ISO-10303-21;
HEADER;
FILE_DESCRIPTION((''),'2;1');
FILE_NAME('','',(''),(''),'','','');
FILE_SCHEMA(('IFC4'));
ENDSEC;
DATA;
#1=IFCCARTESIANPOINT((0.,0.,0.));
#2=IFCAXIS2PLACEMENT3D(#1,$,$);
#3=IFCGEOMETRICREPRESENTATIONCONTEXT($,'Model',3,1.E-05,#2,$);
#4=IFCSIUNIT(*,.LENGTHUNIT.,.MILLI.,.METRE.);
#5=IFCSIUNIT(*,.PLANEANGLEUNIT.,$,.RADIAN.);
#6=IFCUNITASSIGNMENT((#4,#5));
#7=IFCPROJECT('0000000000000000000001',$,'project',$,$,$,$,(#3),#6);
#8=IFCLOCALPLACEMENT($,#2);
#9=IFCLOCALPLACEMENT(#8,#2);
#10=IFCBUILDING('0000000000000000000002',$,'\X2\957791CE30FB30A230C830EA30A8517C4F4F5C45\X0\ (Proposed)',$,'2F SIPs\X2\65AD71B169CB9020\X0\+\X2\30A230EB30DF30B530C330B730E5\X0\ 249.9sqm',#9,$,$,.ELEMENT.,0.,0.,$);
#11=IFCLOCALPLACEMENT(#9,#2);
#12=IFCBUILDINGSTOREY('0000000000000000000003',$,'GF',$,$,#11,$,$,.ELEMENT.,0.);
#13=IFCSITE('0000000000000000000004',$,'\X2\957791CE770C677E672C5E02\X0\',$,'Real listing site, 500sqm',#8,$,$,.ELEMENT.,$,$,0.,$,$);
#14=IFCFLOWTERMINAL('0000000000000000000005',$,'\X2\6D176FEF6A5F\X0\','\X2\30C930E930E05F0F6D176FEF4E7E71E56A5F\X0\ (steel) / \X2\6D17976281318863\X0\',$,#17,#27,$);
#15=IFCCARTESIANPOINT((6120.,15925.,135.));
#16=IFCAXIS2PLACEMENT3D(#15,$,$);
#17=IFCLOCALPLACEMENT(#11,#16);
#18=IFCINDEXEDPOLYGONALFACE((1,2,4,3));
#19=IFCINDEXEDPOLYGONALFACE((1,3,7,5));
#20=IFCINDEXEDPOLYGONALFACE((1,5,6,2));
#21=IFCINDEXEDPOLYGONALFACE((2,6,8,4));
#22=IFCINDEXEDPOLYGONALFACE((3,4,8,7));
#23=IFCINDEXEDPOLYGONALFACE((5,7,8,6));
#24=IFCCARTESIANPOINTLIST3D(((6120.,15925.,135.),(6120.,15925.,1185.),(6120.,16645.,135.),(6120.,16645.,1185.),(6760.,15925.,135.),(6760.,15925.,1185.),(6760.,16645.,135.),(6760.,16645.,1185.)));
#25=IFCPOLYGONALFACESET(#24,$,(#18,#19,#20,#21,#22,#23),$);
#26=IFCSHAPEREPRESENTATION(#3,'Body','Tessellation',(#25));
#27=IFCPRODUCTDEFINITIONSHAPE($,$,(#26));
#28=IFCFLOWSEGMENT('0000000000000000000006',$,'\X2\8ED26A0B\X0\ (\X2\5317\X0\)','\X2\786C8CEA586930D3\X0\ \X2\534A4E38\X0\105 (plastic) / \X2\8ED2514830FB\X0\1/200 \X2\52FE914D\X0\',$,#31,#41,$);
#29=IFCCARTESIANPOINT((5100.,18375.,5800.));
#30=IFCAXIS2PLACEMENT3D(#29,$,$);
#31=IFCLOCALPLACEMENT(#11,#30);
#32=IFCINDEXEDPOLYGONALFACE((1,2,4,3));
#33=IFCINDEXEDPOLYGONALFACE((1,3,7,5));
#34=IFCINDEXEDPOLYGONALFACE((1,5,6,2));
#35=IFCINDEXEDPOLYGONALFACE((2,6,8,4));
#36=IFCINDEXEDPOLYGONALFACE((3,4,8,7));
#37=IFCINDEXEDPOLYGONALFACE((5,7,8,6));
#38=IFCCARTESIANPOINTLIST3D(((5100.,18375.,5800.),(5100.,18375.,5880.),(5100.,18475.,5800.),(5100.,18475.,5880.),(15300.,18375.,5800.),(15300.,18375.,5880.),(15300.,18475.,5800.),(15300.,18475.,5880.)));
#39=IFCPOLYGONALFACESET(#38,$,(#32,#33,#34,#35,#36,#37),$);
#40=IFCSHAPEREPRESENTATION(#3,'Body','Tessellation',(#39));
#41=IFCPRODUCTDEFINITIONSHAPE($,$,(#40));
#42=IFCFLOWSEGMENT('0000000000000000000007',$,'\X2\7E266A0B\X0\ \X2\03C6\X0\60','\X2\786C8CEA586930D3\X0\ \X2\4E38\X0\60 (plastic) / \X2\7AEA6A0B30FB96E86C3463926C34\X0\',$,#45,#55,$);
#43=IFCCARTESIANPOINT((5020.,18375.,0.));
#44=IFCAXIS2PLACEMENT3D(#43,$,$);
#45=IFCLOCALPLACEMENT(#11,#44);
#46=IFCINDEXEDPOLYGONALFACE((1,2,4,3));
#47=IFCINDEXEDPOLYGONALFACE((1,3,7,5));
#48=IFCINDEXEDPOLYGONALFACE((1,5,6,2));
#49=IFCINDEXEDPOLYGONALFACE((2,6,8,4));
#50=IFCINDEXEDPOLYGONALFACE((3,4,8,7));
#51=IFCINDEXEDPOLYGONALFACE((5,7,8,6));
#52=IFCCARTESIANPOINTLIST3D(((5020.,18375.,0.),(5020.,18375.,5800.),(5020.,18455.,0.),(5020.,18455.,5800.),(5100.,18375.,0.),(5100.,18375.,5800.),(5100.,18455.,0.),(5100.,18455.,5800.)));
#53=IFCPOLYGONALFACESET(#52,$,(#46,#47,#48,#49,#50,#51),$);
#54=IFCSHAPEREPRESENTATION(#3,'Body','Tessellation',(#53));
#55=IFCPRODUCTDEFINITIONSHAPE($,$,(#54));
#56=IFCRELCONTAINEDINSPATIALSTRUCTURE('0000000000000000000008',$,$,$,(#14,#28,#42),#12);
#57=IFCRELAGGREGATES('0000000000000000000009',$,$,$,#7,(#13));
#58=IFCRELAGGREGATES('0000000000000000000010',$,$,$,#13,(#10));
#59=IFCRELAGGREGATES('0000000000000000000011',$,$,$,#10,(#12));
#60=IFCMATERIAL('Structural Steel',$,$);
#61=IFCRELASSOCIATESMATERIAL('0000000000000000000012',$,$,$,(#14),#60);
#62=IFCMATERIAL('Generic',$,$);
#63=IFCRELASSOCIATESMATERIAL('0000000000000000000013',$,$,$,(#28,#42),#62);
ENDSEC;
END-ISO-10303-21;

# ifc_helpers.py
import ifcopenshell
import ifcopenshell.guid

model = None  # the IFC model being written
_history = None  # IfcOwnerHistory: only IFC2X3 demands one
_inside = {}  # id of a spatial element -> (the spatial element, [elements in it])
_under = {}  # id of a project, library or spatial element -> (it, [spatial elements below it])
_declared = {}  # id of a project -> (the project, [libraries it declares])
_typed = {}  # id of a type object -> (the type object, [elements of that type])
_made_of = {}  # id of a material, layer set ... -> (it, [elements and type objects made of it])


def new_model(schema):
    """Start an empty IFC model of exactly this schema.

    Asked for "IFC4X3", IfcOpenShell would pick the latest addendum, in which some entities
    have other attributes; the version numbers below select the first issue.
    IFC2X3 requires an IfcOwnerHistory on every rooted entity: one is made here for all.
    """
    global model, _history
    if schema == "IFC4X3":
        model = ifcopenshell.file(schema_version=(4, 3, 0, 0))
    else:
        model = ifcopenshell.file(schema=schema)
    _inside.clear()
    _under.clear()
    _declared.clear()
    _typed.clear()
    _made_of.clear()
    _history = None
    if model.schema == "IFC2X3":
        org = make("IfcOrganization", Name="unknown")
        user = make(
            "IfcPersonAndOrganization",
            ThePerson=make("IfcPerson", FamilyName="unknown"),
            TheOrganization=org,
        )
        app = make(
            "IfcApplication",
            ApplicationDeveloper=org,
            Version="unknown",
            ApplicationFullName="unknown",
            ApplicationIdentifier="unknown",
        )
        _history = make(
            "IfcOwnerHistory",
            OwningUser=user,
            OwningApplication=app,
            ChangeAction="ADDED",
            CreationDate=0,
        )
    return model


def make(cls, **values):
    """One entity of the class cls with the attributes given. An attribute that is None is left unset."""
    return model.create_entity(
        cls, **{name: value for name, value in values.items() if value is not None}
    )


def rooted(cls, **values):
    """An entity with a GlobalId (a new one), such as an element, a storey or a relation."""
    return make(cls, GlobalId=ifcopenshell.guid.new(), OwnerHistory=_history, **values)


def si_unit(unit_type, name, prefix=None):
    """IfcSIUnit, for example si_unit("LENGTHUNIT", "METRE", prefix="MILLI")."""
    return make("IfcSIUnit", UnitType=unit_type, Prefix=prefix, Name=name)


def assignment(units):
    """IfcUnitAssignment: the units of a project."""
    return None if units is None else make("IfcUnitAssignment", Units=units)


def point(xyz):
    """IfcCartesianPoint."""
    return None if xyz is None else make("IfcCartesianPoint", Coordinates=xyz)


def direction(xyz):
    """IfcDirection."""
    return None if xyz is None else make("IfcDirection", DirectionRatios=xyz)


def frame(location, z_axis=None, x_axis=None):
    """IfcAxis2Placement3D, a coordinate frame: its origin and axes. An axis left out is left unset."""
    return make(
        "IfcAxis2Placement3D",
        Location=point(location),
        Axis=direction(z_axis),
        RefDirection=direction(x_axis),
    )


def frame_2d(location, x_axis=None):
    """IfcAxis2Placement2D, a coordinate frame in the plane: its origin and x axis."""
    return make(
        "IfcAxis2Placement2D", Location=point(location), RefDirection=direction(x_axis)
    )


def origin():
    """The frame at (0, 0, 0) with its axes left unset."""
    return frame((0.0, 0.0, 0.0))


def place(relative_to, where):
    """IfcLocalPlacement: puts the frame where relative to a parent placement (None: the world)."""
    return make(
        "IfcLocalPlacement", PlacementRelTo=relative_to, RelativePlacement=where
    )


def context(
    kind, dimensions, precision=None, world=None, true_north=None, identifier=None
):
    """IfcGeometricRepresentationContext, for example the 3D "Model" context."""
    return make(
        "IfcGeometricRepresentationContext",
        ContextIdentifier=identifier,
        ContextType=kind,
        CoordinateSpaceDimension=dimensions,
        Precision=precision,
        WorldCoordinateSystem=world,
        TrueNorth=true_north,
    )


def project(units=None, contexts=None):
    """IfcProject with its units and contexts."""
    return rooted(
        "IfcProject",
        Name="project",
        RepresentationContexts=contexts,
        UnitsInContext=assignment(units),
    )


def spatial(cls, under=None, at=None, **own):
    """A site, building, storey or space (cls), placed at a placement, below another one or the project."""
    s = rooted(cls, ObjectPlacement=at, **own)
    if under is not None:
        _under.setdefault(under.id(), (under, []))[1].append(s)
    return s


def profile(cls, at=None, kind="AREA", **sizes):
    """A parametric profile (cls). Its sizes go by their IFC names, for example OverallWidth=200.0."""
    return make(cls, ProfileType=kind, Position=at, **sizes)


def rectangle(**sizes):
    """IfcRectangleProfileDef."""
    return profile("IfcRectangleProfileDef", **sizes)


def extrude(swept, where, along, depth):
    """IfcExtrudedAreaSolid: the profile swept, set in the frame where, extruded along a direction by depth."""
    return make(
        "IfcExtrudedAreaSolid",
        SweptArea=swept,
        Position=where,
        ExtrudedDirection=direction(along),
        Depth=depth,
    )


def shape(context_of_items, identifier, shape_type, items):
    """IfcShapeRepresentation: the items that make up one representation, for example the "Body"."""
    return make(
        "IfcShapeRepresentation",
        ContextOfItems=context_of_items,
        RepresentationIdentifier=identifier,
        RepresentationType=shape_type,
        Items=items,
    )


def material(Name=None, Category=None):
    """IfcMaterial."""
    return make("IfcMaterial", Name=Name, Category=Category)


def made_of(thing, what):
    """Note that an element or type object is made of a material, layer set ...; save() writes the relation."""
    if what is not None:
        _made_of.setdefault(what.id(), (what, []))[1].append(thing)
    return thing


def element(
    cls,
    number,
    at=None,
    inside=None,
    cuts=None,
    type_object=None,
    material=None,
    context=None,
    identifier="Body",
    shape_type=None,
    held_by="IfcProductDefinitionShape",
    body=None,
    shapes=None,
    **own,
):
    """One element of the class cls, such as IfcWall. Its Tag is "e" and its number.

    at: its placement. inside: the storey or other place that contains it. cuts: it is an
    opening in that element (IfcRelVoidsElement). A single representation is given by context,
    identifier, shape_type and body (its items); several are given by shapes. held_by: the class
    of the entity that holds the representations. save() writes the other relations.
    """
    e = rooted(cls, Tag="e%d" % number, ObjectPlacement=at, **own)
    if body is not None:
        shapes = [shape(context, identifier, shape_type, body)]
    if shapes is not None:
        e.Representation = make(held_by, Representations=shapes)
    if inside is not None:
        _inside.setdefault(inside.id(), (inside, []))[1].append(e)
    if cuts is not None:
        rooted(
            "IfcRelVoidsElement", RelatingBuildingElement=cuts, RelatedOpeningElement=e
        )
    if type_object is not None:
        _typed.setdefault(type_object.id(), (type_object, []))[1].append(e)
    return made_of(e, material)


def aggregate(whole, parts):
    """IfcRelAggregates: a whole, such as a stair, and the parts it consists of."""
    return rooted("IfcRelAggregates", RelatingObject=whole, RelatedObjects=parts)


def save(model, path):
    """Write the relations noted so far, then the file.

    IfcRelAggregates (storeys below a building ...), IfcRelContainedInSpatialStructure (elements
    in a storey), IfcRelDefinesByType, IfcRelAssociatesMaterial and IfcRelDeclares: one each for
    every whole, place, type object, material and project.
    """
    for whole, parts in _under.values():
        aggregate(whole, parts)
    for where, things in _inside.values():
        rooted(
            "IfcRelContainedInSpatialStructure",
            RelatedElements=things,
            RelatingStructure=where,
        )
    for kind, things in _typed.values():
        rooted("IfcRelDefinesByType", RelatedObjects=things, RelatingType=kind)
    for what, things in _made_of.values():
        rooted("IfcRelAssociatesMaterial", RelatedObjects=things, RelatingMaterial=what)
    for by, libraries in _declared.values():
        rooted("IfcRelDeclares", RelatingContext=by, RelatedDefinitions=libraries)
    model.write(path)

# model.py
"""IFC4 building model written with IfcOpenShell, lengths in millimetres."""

from ifc_helpers import new_model, si_unit, frame, frame_2d, origin, place, context, project, spatial, rectangle, extrude, material, element, save


model = new_model("IFC4")

# Units and contexts
model_context = context("Model", 3, precision=1e-05, world=origin())
ifc_project = project(units=[si_unit("LENGTHUNIT", "METRE", prefix="MILLI"), si_unit("PLANEANGLEUNIT", "RADIAN")], contexts=[model_context])

# Site, building, storey
site_placement = place(None, origin())
site = spatial("IfcSite", under=ifc_project, at=site_placement, Name="長野県松本市", ObjectType="Real listing site, 500sqm", CompositionType="ELEMENT", RefElevation=0.0)
building_placement = place(site_placement, origin())
building = spatial("IfcBuilding", under=site, at=building_placement, Name="長野・アトリエ兼住居 (Proposed)", ObjectType="2F SIPs断熱構造+アルミサッシュ 249.9sqm", CompositionType="ELEMENT", ElevationOfRefHeight=0.0, ElevationOfTerrain=0.0)
storey_placement = place(building_placement, origin())
storey = spatial("IfcBuildingStorey", under=building, at=storey_placement, Name="GF", CompositionType="ELEMENT", Elevation=0.0)

# Flow terminal
ifc_material_1 = material(Name="Structural Steel")
flow_terminal_placement = place(storey_placement, frame((6120.0, 15925.0, 135.0)))
element("IfcFlowTerminal", 1, at=flow_terminal_placement, inside=storey, material=ifc_material_1, Name="洗濯機", Description="ドラム式洗濯乾燥機 (steel) / 洗面脱衣", context=model_context, shape_type="SweptSolid", body=[
    extrude(rectangle(XDim=640.0, YDim=720.0, at=frame_2d((320.0, 360.0))), frame((6120.0, 15925.0, 135.0)), (0.0, 0.0, 1.0), 1050.0),
])

# Flow segments
ifc_material_2 = material(Name="Generic")
flow_segment_1_placement = place(storey_placement, frame((5100.0, 18375.0, 5800.0)))
element("IfcFlowSegment", 2, at=flow_segment_1_placement, inside=storey, material=ifc_material_2, Name="軒樋 (北)", Description="硬質塩ビ 半丸105 (plastic) / 軒先・1/200 勾配", context=model_context, shape_type="SweptSolid", body=[
    extrude(rectangle(XDim=10200.0, YDim=100.0, at=frame_2d((5100.0, 50.0))), frame((5100.0, 18375.0, 5800.0)), (0.0, 0.0, 1.0), 80.0),
])
flow_segment_2_placement = place(storey_placement, frame((5020.0, 18375.0, 0.0)))
element("IfcFlowSegment", 3, at=flow_segment_2_placement, inside=storey, material=ifc_material_2, Name="縦樋 φ60", Description="硬質塩ビ 丸60 (plastic) / 竪樋・雨水排水", context=model_context, shape_type="SweptSolid", body=[
    extrude(rectangle(XDim=80.0, YDim=80.0, at=frame_2d((40.0, 40.0))), frame((5020.0, 18375.0, 0.0)), (0.0, 0.0, 1.0), 5800.0),
])

save(model, "model.ifc")
